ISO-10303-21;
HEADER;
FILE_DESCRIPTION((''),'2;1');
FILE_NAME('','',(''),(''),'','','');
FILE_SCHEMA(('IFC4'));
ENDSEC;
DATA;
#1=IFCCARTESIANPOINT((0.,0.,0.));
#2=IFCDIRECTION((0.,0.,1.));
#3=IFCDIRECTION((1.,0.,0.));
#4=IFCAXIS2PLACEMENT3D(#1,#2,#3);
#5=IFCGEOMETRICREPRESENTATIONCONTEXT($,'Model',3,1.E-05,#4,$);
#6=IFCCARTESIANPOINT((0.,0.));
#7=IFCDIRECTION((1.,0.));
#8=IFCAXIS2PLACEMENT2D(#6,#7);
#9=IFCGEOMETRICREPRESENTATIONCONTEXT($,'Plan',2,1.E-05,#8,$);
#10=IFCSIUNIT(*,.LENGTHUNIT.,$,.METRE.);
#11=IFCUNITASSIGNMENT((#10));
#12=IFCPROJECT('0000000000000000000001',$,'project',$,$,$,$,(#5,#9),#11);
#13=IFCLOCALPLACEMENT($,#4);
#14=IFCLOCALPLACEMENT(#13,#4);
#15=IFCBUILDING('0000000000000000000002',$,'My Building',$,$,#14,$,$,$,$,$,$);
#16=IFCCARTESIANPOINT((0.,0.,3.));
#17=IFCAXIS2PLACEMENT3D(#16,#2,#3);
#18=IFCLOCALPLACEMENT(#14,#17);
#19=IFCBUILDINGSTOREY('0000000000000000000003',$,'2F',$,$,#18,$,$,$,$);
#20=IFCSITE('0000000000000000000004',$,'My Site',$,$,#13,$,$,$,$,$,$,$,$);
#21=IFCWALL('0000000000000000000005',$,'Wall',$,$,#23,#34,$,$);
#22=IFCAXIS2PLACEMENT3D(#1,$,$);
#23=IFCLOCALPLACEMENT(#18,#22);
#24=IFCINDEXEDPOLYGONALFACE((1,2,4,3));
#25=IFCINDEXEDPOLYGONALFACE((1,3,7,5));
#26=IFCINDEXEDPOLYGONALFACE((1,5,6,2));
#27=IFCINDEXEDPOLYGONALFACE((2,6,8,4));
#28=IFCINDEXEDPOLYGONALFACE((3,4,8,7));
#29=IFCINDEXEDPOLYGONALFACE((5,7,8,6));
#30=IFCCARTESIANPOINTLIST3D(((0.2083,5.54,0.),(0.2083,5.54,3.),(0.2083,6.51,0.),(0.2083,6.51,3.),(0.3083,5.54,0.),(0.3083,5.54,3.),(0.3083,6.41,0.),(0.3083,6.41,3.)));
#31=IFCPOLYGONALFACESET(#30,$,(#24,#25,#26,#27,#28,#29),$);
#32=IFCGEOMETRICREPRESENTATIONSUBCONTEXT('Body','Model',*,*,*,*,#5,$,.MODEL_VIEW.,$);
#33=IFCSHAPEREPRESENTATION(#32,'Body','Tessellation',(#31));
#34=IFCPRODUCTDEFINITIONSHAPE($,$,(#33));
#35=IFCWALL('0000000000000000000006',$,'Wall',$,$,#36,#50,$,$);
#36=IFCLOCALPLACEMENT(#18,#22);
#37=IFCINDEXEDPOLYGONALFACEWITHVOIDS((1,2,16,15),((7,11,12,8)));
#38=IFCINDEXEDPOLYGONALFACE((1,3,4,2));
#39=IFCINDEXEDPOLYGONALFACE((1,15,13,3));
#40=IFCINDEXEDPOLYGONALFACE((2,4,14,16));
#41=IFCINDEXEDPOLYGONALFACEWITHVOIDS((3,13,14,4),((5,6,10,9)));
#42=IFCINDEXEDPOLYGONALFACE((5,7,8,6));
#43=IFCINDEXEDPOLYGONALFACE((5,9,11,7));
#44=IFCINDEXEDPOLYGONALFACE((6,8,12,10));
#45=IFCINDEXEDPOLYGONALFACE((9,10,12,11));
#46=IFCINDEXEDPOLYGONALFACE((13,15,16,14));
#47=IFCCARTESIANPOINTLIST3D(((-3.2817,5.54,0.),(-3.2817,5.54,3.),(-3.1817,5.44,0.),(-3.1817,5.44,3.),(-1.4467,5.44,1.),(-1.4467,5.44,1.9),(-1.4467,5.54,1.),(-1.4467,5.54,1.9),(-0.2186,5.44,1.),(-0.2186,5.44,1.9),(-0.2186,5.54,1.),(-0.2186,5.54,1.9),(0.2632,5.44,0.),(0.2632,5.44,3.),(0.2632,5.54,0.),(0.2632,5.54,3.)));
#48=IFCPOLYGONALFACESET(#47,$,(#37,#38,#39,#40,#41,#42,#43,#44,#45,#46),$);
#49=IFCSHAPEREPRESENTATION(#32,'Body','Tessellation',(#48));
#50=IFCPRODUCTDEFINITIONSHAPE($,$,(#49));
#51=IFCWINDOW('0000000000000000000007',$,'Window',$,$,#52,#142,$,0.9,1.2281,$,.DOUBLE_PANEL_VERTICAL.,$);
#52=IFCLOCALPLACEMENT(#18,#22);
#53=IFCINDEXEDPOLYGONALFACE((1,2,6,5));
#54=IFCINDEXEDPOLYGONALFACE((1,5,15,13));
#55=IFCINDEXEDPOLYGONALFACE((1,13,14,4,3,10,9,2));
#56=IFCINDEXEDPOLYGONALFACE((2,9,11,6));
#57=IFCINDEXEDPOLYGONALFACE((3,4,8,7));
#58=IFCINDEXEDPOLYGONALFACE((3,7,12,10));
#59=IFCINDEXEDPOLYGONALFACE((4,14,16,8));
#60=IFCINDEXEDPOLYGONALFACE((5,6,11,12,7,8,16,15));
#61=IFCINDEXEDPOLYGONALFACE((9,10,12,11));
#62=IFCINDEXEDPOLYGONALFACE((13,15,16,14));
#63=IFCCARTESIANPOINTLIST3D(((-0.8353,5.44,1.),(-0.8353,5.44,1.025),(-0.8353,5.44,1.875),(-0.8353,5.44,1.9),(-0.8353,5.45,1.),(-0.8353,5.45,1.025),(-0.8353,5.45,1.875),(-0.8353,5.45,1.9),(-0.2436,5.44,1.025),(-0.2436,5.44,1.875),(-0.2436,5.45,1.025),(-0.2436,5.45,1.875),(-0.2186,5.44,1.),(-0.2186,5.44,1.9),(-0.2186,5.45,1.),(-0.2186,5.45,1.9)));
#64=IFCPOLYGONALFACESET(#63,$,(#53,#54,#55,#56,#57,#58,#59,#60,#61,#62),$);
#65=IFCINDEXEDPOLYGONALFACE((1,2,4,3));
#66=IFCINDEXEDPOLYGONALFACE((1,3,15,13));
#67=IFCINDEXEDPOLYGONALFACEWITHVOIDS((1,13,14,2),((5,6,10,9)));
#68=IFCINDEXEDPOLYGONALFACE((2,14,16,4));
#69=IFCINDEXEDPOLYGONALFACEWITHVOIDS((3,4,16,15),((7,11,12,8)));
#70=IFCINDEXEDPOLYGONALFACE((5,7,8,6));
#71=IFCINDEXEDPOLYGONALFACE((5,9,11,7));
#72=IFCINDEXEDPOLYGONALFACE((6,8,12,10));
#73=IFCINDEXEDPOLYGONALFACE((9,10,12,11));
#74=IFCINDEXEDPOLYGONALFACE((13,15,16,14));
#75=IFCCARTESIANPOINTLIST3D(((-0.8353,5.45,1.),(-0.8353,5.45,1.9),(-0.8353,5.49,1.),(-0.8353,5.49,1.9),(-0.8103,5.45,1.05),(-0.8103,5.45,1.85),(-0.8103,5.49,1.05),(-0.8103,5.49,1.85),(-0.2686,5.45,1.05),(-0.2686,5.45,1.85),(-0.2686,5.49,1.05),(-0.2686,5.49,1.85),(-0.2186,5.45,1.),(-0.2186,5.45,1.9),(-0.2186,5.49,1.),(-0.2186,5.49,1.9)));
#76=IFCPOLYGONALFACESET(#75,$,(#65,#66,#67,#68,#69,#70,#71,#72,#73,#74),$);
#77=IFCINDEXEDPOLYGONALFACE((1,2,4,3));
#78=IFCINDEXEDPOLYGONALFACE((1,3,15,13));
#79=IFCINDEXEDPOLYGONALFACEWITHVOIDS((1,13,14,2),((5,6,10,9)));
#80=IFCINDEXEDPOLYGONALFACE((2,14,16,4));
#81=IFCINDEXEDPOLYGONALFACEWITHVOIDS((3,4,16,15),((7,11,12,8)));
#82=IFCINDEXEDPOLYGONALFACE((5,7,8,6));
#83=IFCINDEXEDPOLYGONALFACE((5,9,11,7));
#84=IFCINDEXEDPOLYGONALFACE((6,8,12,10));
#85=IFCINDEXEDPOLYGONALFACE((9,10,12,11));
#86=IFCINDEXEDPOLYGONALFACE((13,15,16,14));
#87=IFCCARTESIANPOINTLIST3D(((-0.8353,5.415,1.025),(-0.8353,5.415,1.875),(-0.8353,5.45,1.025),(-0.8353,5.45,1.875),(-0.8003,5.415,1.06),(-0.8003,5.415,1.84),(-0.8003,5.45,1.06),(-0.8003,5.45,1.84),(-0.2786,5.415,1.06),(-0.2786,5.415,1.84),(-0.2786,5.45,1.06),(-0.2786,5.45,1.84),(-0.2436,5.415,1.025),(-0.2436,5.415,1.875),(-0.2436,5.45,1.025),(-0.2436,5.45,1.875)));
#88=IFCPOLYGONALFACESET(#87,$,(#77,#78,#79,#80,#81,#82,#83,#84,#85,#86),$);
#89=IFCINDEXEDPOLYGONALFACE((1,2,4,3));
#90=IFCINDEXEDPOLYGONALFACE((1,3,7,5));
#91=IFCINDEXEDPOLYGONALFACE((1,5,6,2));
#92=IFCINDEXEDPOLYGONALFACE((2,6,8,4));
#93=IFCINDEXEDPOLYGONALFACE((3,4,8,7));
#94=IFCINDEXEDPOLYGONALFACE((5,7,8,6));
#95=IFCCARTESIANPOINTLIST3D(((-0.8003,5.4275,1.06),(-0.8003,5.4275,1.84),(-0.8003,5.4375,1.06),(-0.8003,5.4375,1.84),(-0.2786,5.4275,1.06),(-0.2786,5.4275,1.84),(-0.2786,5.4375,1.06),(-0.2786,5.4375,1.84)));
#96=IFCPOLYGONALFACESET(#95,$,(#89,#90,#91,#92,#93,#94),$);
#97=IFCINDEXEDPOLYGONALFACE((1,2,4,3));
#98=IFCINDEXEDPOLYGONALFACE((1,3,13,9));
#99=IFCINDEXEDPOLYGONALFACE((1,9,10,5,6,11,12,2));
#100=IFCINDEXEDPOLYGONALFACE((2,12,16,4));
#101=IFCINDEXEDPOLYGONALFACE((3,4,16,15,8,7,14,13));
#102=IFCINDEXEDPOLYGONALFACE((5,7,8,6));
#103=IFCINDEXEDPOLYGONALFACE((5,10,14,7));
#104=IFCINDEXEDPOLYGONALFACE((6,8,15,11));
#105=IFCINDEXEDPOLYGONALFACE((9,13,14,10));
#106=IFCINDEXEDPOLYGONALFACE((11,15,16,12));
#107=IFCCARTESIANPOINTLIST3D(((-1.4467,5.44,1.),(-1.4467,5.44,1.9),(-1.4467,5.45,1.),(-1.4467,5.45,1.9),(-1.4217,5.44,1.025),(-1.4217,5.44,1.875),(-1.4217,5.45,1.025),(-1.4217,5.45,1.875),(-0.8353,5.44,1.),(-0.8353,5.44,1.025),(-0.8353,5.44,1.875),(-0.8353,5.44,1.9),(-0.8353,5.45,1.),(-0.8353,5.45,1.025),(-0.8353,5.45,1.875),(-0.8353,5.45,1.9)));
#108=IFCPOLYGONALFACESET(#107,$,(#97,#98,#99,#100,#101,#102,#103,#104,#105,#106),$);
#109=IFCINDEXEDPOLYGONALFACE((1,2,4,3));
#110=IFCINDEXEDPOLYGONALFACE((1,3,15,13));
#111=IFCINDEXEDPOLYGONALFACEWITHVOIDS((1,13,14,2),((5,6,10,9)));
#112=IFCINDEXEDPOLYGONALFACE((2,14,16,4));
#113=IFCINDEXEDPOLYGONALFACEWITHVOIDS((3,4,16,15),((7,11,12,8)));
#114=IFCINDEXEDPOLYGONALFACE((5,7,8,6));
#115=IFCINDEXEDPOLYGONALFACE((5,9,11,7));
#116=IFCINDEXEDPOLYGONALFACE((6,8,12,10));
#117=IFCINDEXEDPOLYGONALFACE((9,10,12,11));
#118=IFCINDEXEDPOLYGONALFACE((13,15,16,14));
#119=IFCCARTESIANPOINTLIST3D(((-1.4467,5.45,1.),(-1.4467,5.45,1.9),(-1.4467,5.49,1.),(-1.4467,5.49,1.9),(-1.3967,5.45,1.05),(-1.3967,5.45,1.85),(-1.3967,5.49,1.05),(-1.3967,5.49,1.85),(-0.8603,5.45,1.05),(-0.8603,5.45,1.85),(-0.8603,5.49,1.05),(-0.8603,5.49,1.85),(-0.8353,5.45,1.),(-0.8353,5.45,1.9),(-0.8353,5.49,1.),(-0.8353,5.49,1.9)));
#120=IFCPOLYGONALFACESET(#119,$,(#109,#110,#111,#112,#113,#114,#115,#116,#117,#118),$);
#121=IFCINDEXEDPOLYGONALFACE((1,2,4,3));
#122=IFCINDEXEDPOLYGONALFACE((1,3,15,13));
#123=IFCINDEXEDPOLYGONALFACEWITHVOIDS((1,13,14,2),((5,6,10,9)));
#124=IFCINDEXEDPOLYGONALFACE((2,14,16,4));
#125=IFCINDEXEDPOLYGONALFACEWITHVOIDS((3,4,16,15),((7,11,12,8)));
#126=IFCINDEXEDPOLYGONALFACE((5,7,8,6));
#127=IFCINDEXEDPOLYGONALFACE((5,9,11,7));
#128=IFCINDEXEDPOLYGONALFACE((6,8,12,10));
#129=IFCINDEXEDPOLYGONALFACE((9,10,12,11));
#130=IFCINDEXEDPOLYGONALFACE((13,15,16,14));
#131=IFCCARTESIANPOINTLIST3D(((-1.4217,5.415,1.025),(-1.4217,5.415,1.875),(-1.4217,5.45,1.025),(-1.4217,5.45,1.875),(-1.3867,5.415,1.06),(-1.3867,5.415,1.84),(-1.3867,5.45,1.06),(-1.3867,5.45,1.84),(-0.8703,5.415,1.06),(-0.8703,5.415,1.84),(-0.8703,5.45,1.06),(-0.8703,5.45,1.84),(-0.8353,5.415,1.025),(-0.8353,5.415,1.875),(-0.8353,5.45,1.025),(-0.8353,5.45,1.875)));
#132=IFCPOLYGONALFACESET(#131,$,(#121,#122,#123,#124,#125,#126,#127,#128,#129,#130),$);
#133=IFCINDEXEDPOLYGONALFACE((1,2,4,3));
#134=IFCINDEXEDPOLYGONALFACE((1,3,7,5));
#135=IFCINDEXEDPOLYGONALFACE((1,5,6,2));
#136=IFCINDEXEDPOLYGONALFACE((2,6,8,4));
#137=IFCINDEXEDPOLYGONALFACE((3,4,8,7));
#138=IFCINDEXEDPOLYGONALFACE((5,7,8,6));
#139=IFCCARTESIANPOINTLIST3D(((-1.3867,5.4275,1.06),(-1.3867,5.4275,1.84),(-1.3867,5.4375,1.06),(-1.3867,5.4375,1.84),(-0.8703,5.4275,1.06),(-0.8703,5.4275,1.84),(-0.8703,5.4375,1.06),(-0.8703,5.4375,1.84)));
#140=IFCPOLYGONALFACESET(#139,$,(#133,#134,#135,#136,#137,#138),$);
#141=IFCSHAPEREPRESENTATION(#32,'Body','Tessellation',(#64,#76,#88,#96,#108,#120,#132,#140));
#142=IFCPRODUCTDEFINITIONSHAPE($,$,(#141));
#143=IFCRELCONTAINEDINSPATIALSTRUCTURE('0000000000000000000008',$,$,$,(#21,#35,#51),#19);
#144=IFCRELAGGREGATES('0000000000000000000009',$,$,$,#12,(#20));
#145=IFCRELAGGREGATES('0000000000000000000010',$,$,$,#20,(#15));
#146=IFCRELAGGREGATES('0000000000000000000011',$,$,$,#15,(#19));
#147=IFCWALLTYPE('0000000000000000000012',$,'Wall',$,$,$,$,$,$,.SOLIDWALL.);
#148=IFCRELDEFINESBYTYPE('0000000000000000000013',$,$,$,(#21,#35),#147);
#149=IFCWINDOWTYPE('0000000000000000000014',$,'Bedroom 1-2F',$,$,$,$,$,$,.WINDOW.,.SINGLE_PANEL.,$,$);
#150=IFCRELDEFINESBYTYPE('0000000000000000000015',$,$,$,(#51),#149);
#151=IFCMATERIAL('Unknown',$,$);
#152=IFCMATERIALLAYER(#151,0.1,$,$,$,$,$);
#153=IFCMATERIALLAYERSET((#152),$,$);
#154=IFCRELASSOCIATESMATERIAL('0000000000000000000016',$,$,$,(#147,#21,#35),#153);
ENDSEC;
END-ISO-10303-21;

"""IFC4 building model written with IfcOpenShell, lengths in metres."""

from ifc_helpers import new_model, entity, si_unit, frame, origin_with_axes, origin_2d_with_axis, place, context, subcontext, project, spatial, line, indexed_curve, outline, extrude, shape, source, transform, mapped, material, layer, layer_set, layer_usage, type_object, type_shapes, element, fill, save


model = new_model("IFC4")

# Units and contexts
model_context = context("Model", 3, precision=1e-05, world=origin_with_axes())
plan_context = context("Plan", 2, precision=1e-05, world=origin_2d_with_axis())
body_context_1 = subcontext(model_context, "Body", "Model", "MODEL_VIEW")
body_context_2 = subcontext(plan_context, "Body", "Plan", "PLAN_VIEW")
ifc_project = project(units=[si_unit("LENGTHUNIT", "METRE")], contexts=[model_context, plan_context])

# Site, building, storey
site_placement = place(None, origin_with_axes())
site = spatial("IfcSite", under=ifc_project, at=site_placement, Name="My Site")
building_placement = place(site_placement, origin_with_axes())
building = spatial("IfcBuilding", under=site, at=building_placement, Name="My Building")
storey_placement = place(building_placement, frame((0.0, 0.0, 3.0), z_axis=(0.0, 0.0, 1.0), x_axis=(1.0, 0.0, 0.0)))
storey = spatial("IfcBuildingStorey", under=building, at=storey_placement, Name="2F")

# Shared definitions
ifc_material_1 = material(Name="Unknown")

# Wall
ifc_layer_1 = layer(ifc_material_1, 0.1)
ifc_layer_set_1 = layer_set([ifc_layer_1])
wall_type = type_object("IfcWallType", Name="Wall", PredefinedType="SOLIDWALL", material=ifc_layer_set_1)
ifc_layer_usage_1 = layer_usage(ifc_layer_set_1, "AXIS2", "POSITIVE", 0.0)
wall_1_placement = place(storey_placement, frame((0.2083, 6.51, 0.0), z_axis=(0.0, 0.0, 1.0), x_axis=(0.0, -1.0, 0.0)))
element("IfcWall", 1, at=wall_1_placement, inside=storey, type_object=wall_type, material=ifc_layer_usage_1, Name="Wall", context=body_context_1, shape_type="SweptSolid", body=[
    extrude(outline(indexed_curve([(0.0, 0.0), (0.1, 0.1), (0.97, 0.1), (0.97, 0.0)], segments=[line(1, 2, 3, 4, 1)])), origin_with_axes(), (0.0, 0.0, 1.0), 3.0),
])

# Wall, opening, window
ifc_layer_usage_2 = layer_usage(ifc_layer_set_1, "AXIS2", "POSITIVE", 0.0)
wall_2_placement = place(storey_placement, frame((0.2632, 5.54, 0.0), z_axis=(0.0, 0.0, 1.0), x_axis=(-1.0, 0.0, 0.0)))
wall_2 = element("IfcWall", 2, at=wall_2_placement, inside=storey, type_object=wall_type, material=ifc_layer_usage_2, Name="Wall", context=body_context_1, shape_type="SweptSolid", body=[
    extrude(outline(indexed_curve([(0.0, 0.0), (0.0, 0.1), (3.4448, 0.1), (3.5448, 0.0)], segments=[line(1, 2, 3, 4, 1)])), origin_with_axes(), (0.0, 0.0, 1.0), 3.0),
])
shared_shape_1 = source(origin_with_axes(), body_context_1, "Body", "SweptSolid", [
    extrude(outline(indexed_curve([(0.0, 0.0), (1.2281, 0.0), (1.2281, 0.9), (0.0, 0.9)], segments=[line(1, 2, 3, 4, 1)])), frame((0.0, -0.6, 0.0), z_axis=(0.0, -1.0, 0.0), x_axis=(1.0, 0.0, 0.0)), (0.0, 0.0, -1.0), 1.2),
])
opening_1_placement = place(wall_2_placement, frame((0.4818, 0.0, 1.0), z_axis=(0.0, 0.0, 1.0), x_axis=(1.0, 0.0, 0.0)))
opening_1 = element("IfcOpeningElement", 3, at=opening_1_placement, cuts=wall_2, PredefinedType="OPENING", context=body_context_1, shape_type="MappedRepresentation", body=[
    mapped(shared_shape_1, transform((0.0, 0.0, 0.0), x_axis=(1.0, 0.0, 0.0), y_axis=(0.0, 1.0, 0.0), z_axis=(0.0, 0.0, 1.0), scale=1.0)),
])
window_type_1 = type_object("IfcWindowType", Name="Bedroom 1-2F", PartitioningType="SINGLE_PANEL", PredefinedType="WINDOW")
shared_shape_2 = source(origin_with_axes(), body_context_1, "Body", "SweptSolid", [
    extrude(outline(indexed_curve([(0.6167, 0.0), (0.0, 0.0), (0.0, 0.9), (0.6167, 0.9), (0.6167, 0.875), (0.025, 0.875), (0.025, 0.025), (0.6167, 0.025)], segments=[line(1, 2, 3, 4, 5, 6, 7, 8, 1)])), frame((0.0, 0.09, 0.0), z_axis=(0.0, -1.0, 0.0), x_axis=(1.0, 0.0, 0.0)), (0.0, 0.0, -1.0), 0.01),
    extrude(outline(indexed_curve([(0.0, 0.0), (0.6167, 0.0), (0.6167, 0.9), (0.0, 0.9)], segments=[line(1, 2, 3, 4, 1)]), holes=[indexed_curve([(0.05, 0.05), (0.5917, 0.05), (0.5917, 0.85), (0.05, 0.85)], segments=[line(1, 2, 3, 4, 1)])]), frame((0.0, 0.05, 0.0), z_axis=(0.0, -1.0, 0.0), x_axis=(1.0, 0.0, 0.0)), (0.0, 0.0, -1.0), 0.04),
    extrude(outline(indexed_curve([(0.0, 0.0), (0.5917, 0.0), (0.5917, 0.85), (0.0, 0.85)], segments=[line(1, 2, 3, 4, 1)]), holes=[indexed_curve([(0.035, 0.035), (0.5567, 0.035), (0.5567, 0.815), (0.035, 0.815)], segments=[line(1, 2, 3, 4, 1)])]), frame((0.025, 0.09, 0.025), z_axis=(0.0, -1.0, 0.0), x_axis=(1.0, 0.0, 0.0)), (0.0, 0.0, -1.0), 0.035),
    extrude(outline(indexed_curve([(0.035, 0.035), (0.5567, 0.035), (0.5567, 0.815), (0.035, 0.815)], segments=[line(1, 2, 3, 4, 1)])), frame((0.025, 0.1025, 0.025), z_axis=(0.0, -1.0, 0.0), x_axis=(1.0, 0.0, 0.0)), (0.0, 0.0, -1.0), 0.01),
    extrude(outline(indexed_curve([(0.0, 0.9), (0.6114, 0.9), (0.6114, 0.0), (0.0, 0.0), (0.0, 0.025), (0.5864, 0.025), (0.5864, 0.875), (0.0, 0.875)], segments=[line(1, 2, 3, 4, 5, 6, 7, 8, 1)])), frame((0.6167, 0.09, 0.0), z_axis=(0.0, -1.0, 0.0), x_axis=(1.0, 0.0, 0.0)), (0.0, 0.0, -1.0), 0.01),
    extrude(outline(indexed_curve([(0.0, 0.0), (0.6114, 0.0), (0.6114, 0.9), (0.0, 0.9)], segments=[line(1, 2, 3, 4, 1)]), holes=[indexed_curve([(0.025, 0.05), (0.5614, 0.05), (0.5614, 0.85), (0.025, 0.85)], segments=[line(1, 2, 3, 4, 1)])]), frame((0.6167, 0.05, 0.0), z_axis=(0.0, -1.0, 0.0), x_axis=(1.0, 0.0, 0.0)), (0.0, 0.0, -1.0), 0.04),
    extrude(outline(indexed_curve([(0.0, 0.0), (0.5864, 0.0), (0.5864, 0.85), (0.0, 0.85)], segments=[line(1, 2, 3, 4, 1)]), holes=[indexed_curve([(0.035, 0.035), (0.5514, 0.035), (0.5514, 0.815), (0.035, 0.815)], segments=[line(1, 2, 3, 4, 1)])]), frame((0.6167, 0.09, 0.025), z_axis=(0.0, -1.0, 0.0), x_axis=(1.0, 0.0, 0.0)), (0.0, 0.0, -1.0), 0.035),
    extrude(outline(indexed_curve([(0.035, 0.035), (0.5514, 0.035), (0.5514, 0.815), (0.035, 0.815)], segments=[line(1, 2, 3, 4, 1)])), frame((0.6167, 0.1025, 0.025), z_axis=(0.0, -1.0, 0.0), x_axis=(1.0, 0.0, 0.0)), (0.0, 0.0, -1.0), 0.01),
])
shared_shape_3 = source(origin_with_axes(), body_context_2, "Body", "Curve2D", [
    entity("IfcIndexedPolyCurve", entity("IfcCartesianPointList2D", [[0.05, 0.05], [0.5917, 0.05]])),
    entity("IfcIndexedPolyCurve", entity("IfcCartesianPointList2D", [[0.0, 0.1], [0.025, 0.1], [0.025, 0.09], [0.05, 0.09], [0.05, 0.05], [0.0, 0.05]]), [entity("IfcLineIndex", [1, 2, 3, 4, 5, 6, 1])]),
    entity("IfcIndexedPolyCurve", entity("IfcCartesianPointList2D", [[0.6167, 0.1], [0.6167, 0.1], [0.6167, 0.09], [0.5917, 0.09], [0.5917, 0.05], [0.6167, 0.05]])),
    entity("IfcIndexedPolyCurve", entity("IfcCartesianPointList2D", [[0.025, 0.09], [0.06, 0.09], [0.06, 0.125], [0.025, 0.125]]), [entity("IfcLineIndex", [1, 2, 3, 4, 1])]),
    entity("IfcIndexedPolyCurve", entity("IfcCartesianPointList2D", [[0.6167, 0.09], [0.5817, 0.09], [0.5817, 0.125], [0.6167, 0.125]]), [entity("IfcLineIndex", [1, 2, 3, 4, 1])]),
    entity("IfcIndexedPolyCurve", entity("IfcCartesianPointList2D", [[0.06, 0.09], [0.5817, 0.09]])),
    entity("IfcIndexedPolyCurve", entity("IfcCartesianPointList2D", [[0.06, 0.125], [0.5817, 0.125]])),
    entity("IfcIndexedPolyCurve", entity("IfcCartesianPointList2D", [[0.06, 0.1075], [0.5817, 0.1075]])),
    entity("IfcIndexedPolyCurve", entity("IfcCartesianPointList2D", [[0.6417, 0.05], [1.1781, 0.05]])),
    entity("IfcIndexedPolyCurve", entity("IfcCartesianPointList2D", [[0.6167, 0.1], [0.6167, 0.1], [0.6167, 0.09], [0.6417, 0.09], [0.6417, 0.05], [0.6167, 0.05]])),
    entity("IfcIndexedPolyCurve", entity("IfcCartesianPointList2D", [[1.2281, 0.1], [1.2031, 0.1], [1.2031, 0.09], [1.1781, 0.09], [1.1781, 0.05], [1.2281, 0.05]]), [entity("IfcLineIndex", [1, 2, 3, 4, 5, 6, 1])]),
    entity("IfcIndexedPolyCurve", entity("IfcCartesianPointList2D", [[0.6167, 0.09], [0.6517, 0.09], [0.6517, 0.125], [0.6167, 0.125]]), [entity("IfcLineIndex", [1, 2, 3, 4, 1])]),
    entity("IfcIndexedPolyCurve", entity("IfcCartesianPointList2D", [[1.2031, 0.09], [1.1681, 0.09], [1.1681, 0.125], [1.2031, 0.125]]), [entity("IfcLineIndex", [1, 2, 3, 4, 1])]),
    entity("IfcIndexedPolyCurve", entity("IfcCartesianPointList2D", [[0.6517, 0.09], [1.1681, 0.09]])),
    entity("IfcIndexedPolyCurve", entity("IfcCartesianPointList2D", [[0.6517, 0.125], [1.1681, 0.125]])),
    entity("IfcIndexedPolyCurve", entity("IfcCartesianPointList2D", [[0.6517, 0.1075], [1.1681, 0.1075]])),
])
type_shapes(window_type_1, [shared_shape_2, shared_shape_3])
window_1_placement = place(opening_1_placement, origin_with_axes())
window_1 = element("IfcWindow", 4, at=window_1_placement, inside=storey, type_object=window_type_1, Name="Window", OverallHeight=0.9, OverallWidth=1.2281, PartitioningType="DOUBLE_PANEL_VERTICAL", shapes=[
    shape(body_context_1, "Body", "MappedRepresentation", [mapped(shared_shape_2, transform((0.0, 0.0, 0.0), x_axis=(1.0, 0.0, 0.0), y_axis=(0.0, 1.0, 0.0), z_axis=(0.0, 0.0, 1.0), scale=1.0))]),
    shape(body_context_2, "Body", "MappedRepresentation", [mapped(shared_shape_3, transform((0.0, 0.0, 0.0), x_axis=(1.0, 0.0, 0.0), y_axis=(0.0, 1.0, 0.0), z_axis=(0.0, 0.0, 1.0), scale=1.0))]),
])
fill(opening_1, window_1)

save(model, "model.ifc")
